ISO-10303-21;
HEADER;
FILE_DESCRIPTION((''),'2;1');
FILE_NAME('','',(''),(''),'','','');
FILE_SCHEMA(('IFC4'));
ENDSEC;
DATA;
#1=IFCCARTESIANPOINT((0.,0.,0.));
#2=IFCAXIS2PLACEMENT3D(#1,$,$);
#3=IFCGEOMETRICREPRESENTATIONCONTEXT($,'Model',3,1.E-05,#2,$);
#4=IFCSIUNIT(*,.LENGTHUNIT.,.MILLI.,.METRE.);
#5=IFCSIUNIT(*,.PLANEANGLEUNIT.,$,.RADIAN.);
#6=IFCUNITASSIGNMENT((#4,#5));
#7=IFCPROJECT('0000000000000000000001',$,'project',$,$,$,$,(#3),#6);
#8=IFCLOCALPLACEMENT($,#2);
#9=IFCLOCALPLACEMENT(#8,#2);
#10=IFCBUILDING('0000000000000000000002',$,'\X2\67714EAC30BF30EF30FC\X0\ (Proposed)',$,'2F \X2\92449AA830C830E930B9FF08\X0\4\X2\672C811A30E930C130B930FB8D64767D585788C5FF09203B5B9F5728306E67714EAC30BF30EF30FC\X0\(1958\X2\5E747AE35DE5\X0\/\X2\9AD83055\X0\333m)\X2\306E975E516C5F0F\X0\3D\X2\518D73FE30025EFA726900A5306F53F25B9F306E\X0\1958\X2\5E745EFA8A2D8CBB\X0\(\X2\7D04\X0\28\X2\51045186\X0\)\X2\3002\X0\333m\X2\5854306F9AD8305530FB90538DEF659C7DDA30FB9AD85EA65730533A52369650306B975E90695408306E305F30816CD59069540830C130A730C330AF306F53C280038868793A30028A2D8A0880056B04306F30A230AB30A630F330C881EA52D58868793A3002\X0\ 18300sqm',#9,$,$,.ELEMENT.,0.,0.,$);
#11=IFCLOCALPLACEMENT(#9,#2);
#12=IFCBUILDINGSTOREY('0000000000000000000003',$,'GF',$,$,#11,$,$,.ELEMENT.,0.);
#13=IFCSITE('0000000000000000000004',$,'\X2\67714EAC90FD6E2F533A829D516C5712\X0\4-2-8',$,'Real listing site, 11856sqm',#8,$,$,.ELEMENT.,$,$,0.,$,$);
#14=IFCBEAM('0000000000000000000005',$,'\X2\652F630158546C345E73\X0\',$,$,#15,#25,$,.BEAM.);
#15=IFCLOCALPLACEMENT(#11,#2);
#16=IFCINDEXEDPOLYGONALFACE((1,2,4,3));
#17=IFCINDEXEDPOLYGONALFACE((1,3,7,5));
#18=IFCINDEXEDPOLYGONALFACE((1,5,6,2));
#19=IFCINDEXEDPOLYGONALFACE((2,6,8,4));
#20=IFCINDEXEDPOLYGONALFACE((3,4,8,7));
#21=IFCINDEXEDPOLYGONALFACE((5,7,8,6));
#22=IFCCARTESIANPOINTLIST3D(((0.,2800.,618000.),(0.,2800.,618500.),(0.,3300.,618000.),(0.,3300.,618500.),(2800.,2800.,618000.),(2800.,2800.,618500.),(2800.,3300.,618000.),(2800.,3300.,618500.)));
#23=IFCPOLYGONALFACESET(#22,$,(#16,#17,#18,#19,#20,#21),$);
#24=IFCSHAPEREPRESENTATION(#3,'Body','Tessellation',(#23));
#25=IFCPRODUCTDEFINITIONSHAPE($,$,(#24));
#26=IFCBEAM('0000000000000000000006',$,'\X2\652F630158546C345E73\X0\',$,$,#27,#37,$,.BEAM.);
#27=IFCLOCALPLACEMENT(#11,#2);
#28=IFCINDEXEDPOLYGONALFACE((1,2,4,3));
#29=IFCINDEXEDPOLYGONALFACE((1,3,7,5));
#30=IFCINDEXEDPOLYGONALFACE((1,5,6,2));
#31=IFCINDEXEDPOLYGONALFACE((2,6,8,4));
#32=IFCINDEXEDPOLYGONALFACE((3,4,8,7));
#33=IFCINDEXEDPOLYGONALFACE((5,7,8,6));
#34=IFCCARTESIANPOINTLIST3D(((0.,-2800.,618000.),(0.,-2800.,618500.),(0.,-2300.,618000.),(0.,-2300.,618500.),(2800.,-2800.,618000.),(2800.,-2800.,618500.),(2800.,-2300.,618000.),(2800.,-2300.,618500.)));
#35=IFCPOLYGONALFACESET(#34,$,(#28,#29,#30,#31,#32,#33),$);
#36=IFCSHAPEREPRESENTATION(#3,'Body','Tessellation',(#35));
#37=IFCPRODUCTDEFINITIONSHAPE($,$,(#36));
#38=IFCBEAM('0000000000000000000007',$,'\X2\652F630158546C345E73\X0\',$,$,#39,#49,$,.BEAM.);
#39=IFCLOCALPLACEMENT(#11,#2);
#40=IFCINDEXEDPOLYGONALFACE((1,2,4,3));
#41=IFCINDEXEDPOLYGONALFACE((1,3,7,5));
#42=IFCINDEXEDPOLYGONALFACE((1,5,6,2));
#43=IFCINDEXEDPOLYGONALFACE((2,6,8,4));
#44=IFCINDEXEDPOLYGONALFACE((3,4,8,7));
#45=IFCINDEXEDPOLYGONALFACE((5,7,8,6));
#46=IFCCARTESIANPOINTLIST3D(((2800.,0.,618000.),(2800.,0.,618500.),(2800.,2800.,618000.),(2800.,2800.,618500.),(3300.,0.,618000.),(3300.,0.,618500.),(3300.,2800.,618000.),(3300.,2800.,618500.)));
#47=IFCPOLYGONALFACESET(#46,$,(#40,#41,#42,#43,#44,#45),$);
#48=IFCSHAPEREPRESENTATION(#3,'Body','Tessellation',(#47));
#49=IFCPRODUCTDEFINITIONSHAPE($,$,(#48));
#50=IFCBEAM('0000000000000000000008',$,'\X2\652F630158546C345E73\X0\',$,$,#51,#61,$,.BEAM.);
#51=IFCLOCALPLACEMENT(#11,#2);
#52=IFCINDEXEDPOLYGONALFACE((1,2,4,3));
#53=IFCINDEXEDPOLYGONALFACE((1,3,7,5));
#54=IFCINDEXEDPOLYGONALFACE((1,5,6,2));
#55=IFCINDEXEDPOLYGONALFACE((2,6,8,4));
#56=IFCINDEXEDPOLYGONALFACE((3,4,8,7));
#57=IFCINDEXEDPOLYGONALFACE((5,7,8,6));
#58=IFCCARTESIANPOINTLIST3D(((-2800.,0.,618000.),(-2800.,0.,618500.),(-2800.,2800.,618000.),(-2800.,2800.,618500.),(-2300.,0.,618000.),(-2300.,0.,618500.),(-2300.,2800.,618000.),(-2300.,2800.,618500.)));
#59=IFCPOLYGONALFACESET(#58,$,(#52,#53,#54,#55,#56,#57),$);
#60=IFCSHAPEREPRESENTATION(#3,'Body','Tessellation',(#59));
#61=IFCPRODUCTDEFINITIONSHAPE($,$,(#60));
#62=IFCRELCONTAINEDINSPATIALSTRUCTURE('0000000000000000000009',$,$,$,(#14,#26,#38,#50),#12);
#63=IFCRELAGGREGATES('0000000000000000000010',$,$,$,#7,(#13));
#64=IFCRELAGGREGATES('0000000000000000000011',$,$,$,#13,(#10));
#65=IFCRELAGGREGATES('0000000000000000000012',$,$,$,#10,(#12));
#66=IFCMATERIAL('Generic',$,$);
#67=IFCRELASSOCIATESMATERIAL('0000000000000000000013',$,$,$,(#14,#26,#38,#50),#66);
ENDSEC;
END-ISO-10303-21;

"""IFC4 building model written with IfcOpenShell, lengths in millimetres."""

from ifc_helpers import new_model, si_unit, frame, frame_2d, origin, place, context, project, spatial, rectangle, extrude, material, element, save


model = new_model("IFC4")

# Units and contexts
model_context = context("Model", 3, precision=1e-05, world=origin())
ifc_project = project(units=[si_unit("LENGTHUNIT", "METRE", prefix="MILLI"), si_unit("PLANEANGLEUNIT", "RADIAN")], contexts=[model_context])

# Site, building, storey
site_placement = place(None, origin())
site = spatial("IfcSite", under=ifc_project, at=site_placement, Name="東京都港区芝公園4-2-8", ObjectType="Real listing site, 11856sqm", CompositionType="ELEMENT", RefElevation=0.0)
building_placement = place(site_placement, origin())
building = spatial("IfcBuilding", under=site, at=building_placement, Name="東京タワー (Proposed)", ObjectType="2F 鉄骨トラス（4本脚ラチス・赤白塗装）※実在の東京タワー(1958年竣工/高さ333m)の非公式3D再現。建物¥は史実の1958年建設費(約28億円)。333m塔は高さ・道路斜線・高度地区制限に非適合のため法適合チェックは参考表示。設計者欄はアカウント自動表示。 18300sqm", CompositionType="ELEMENT", ElevationOfRefHeight=0.0, ElevationOfTerrain=0.0)
storey_placement = place(building_placement, origin())
storey = spatial("IfcBuildingStorey", under=building, at=storey_placement, Name="GF", CompositionType="ELEMENT", Elevation=0.0)

# Shared definitions
ifc_material = material(Name="Generic")

# Beams
beam_1_placement = place(storey_placement, frame((0.0, 1400.0, 309000.0)))
element("IfcBeam", 1, at=beam_1_placement, inside=storey, material=ifc_material, Name="支持塔水平", PredefinedType="BEAM", context=model_context, shape_type="SweptSolid", body=[
    extrude(rectangle(XDim=2800.0, YDim=500.0, at=frame_2d((1400.0, 250.0))), frame((0.0, 1400.0, 309000.0)), (0.0, 0.0, 1.0), 500.0),
])
beam_2_placement = place(storey_placement, frame((0.0, -1400.0, 309000.0)))
element("IfcBeam", 2, at=beam_2_placement, inside=storey, material=ifc_material, Name="支持塔水平", PredefinedType="BEAM", context=model_context, shape_type="SweptSolid", body=[
    extrude(rectangle(XDim=2800.0, YDim=500.0, at=frame_2d((1400.0, 250.0))), frame((0.0, -1400.0, 309000.0)), (0.0, 0.0, 1.0), 500.0),
])
beam_3_placement = place(storey_placement, frame((1400.0, 0.0, 309000.0)))
element("IfcBeam", 3, at=beam_3_placement, inside=storey, material=ifc_material, Name="支持塔水平", PredefinedType="BEAM", context=model_context, shape_type="SweptSolid", body=[
    extrude(rectangle(XDim=500.0, YDim=2800.0, at=frame_2d((250.0, 1400.0))), frame((1400.0, 0.0, 309000.0)), (0.0, 0.0, 1.0), 500.0),
])
beam_4_placement = place(storey_placement, frame((-1400.0, 0.0, 309000.0)))
element("IfcBeam", 4, at=beam_4_placement, inside=storey, material=ifc_material, Name="支持塔水平", PredefinedType="BEAM", context=model_context, shape_type="SweptSolid", body=[
    extrude(rectangle(XDim=500.0, YDim=2800.0, at=frame_2d((250.0, 1400.0))), frame((-1400.0, 0.0, 309000.0)), (0.0, 0.0, 1.0), 500.0),
])

save(model, "model.ifc")
